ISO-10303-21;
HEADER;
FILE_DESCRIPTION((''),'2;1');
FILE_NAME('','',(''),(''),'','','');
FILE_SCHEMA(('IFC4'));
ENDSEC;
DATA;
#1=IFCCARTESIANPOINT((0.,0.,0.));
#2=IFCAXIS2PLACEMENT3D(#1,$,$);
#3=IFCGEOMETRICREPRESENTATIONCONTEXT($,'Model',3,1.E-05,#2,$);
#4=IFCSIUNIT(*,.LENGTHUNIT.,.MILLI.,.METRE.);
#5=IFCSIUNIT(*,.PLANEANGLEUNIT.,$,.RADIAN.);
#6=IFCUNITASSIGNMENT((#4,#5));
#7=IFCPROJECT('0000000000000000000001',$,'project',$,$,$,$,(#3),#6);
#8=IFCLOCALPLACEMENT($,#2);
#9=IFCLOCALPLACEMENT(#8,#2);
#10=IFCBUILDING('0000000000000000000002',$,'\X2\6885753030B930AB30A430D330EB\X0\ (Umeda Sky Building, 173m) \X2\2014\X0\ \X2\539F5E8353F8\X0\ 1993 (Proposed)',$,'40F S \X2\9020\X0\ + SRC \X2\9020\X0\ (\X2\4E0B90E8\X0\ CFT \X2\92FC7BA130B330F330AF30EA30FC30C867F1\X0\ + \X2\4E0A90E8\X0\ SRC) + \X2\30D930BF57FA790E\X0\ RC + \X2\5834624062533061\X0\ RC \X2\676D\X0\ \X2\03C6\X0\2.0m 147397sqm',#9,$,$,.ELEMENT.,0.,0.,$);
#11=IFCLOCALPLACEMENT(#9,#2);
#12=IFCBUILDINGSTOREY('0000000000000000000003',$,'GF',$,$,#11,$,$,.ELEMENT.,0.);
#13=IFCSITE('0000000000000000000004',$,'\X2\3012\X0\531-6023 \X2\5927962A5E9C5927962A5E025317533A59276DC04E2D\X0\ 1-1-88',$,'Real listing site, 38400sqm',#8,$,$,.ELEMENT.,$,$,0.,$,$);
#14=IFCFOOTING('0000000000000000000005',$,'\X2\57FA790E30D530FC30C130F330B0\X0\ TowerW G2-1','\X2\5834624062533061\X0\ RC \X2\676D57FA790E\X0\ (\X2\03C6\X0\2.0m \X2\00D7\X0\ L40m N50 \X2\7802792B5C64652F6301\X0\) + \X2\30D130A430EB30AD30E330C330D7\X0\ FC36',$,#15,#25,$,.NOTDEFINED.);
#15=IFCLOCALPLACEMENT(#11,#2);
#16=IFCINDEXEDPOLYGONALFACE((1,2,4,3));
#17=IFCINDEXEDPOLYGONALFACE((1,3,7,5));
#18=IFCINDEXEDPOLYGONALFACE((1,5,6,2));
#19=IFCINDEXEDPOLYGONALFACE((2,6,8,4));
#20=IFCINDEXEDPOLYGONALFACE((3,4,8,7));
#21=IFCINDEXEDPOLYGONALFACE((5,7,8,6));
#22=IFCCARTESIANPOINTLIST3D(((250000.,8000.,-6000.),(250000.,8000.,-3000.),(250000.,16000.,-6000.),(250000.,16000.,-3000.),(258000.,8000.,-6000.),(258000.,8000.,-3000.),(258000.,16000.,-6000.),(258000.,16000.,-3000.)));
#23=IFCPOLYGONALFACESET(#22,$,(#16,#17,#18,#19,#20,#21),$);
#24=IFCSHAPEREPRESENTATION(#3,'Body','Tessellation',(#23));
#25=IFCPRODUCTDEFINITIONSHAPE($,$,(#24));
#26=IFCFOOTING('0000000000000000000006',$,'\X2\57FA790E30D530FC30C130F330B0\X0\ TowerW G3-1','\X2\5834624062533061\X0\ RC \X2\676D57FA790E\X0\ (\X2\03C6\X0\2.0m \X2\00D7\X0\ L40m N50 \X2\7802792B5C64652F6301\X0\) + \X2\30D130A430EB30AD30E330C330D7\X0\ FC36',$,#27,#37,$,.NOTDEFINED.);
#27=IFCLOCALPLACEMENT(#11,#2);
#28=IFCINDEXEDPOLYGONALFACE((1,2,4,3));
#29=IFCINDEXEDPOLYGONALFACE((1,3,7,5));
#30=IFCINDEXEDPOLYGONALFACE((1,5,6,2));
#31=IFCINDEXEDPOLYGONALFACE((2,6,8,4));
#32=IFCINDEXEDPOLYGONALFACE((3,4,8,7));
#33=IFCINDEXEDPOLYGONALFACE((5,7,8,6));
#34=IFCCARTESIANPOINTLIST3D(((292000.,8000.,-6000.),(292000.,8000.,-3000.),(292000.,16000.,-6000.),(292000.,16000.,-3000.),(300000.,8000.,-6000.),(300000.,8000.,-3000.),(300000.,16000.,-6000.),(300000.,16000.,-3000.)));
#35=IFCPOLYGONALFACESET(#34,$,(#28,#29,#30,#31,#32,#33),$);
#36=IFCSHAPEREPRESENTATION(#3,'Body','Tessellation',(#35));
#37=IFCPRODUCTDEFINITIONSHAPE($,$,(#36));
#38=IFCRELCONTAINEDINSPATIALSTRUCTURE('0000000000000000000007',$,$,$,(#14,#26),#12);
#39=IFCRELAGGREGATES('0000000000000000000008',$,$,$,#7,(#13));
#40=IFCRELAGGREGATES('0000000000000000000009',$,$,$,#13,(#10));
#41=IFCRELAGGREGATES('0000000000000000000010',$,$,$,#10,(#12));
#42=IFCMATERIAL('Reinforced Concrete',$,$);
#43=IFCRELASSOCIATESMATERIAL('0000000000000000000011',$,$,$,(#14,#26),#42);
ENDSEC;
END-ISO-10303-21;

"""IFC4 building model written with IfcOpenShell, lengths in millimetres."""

from ifc_helpers import new_model, si_unit, frame, frame_2d, origin, place, context, project, spatial, rectangle, extrude, material, element, save


model = new_model("IFC4")

# Units and contexts
model_context = context("Model", 3, precision=1e-05, world=origin())
ifc_project = project(units=[si_unit("LENGTHUNIT", "METRE", prefix="MILLI"), si_unit("PLANEANGLEUNIT", "RADIAN")], contexts=[model_context])

# Site, building, storey
site_placement = place(None, origin())
site = spatial("IfcSite", under=ifc_project, at=site_placement, Name="〒531-6023 大阪府大阪市北区大淀中 1-1-88", ObjectType="Real listing site, 38400sqm", CompositionType="ELEMENT", RefElevation=0.0)
building_placement = place(site_placement, origin())
building = spatial("IfcBuilding", under=site, at=building_placement, Name="梅田スカイビル (Umeda Sky Building, 173m) — 原広司 1993 (Proposed)", ObjectType="40F S 造 + SRC 造 (下部 CFT 鋼管コンクリート柱 + 上部 SRC) + ベタ基礎 RC + 場所打ち RC 杭 φ2.0m 147397sqm", CompositionType="ELEMENT", ElevationOfRefHeight=0.0, ElevationOfTerrain=0.0)
storey_placement = place(building_placement, origin())
storey = spatial("IfcBuildingStorey", under=building, at=storey_placement, Name="GF", CompositionType="ELEMENT", Elevation=0.0)

# Footings
ifc_material_1 = material(Name="Reinforced Concrete")
footing_1_placement = place(storey_placement, frame((125000.0, 4000.0, -3000.0)))
element("IfcFooting", 1, at=footing_1_placement, inside=storey, material=ifc_material_1, Name="基礎フーチング TowerW G2-1", Description="場所打ち RC 杭基礎 (φ2.0m × L40m N50 砂礫層支持) + パイルキャップ FC36", PredefinedType="NOTDEFINED", context=model_context, shape_type="SweptSolid", body=[
    extrude(rectangle(XDim=8000.0, YDim=8000.0, at=frame_2d((4000.0, 4000.0))), frame((125000.0, 4000.0, -3000.0)), (0.0, 0.0, 1.0), 3000.0),
])
footing_2_placement = place(storey_placement, frame((146000.0, 4000.0, -3000.0)))
element("IfcFooting", 2, at=footing_2_placement, inside=storey, material=ifc_material_1, Name="基礎フーチング TowerW G3-1", Description="場所打ち RC 杭基礎 (φ2.0m × L40m N50 砂礫層支持) + パイルキャップ FC36", PredefinedType="NOTDEFINED", context=model_context, shape_type="SweptSolid", body=[
    extrude(rectangle(XDim=8000.0, YDim=8000.0, at=frame_2d((4000.0, 4000.0))), frame((146000.0, 4000.0, -3000.0)), (0.0, 0.0, 1.0), 3000.0),
])

save(model, "model.ifc")
